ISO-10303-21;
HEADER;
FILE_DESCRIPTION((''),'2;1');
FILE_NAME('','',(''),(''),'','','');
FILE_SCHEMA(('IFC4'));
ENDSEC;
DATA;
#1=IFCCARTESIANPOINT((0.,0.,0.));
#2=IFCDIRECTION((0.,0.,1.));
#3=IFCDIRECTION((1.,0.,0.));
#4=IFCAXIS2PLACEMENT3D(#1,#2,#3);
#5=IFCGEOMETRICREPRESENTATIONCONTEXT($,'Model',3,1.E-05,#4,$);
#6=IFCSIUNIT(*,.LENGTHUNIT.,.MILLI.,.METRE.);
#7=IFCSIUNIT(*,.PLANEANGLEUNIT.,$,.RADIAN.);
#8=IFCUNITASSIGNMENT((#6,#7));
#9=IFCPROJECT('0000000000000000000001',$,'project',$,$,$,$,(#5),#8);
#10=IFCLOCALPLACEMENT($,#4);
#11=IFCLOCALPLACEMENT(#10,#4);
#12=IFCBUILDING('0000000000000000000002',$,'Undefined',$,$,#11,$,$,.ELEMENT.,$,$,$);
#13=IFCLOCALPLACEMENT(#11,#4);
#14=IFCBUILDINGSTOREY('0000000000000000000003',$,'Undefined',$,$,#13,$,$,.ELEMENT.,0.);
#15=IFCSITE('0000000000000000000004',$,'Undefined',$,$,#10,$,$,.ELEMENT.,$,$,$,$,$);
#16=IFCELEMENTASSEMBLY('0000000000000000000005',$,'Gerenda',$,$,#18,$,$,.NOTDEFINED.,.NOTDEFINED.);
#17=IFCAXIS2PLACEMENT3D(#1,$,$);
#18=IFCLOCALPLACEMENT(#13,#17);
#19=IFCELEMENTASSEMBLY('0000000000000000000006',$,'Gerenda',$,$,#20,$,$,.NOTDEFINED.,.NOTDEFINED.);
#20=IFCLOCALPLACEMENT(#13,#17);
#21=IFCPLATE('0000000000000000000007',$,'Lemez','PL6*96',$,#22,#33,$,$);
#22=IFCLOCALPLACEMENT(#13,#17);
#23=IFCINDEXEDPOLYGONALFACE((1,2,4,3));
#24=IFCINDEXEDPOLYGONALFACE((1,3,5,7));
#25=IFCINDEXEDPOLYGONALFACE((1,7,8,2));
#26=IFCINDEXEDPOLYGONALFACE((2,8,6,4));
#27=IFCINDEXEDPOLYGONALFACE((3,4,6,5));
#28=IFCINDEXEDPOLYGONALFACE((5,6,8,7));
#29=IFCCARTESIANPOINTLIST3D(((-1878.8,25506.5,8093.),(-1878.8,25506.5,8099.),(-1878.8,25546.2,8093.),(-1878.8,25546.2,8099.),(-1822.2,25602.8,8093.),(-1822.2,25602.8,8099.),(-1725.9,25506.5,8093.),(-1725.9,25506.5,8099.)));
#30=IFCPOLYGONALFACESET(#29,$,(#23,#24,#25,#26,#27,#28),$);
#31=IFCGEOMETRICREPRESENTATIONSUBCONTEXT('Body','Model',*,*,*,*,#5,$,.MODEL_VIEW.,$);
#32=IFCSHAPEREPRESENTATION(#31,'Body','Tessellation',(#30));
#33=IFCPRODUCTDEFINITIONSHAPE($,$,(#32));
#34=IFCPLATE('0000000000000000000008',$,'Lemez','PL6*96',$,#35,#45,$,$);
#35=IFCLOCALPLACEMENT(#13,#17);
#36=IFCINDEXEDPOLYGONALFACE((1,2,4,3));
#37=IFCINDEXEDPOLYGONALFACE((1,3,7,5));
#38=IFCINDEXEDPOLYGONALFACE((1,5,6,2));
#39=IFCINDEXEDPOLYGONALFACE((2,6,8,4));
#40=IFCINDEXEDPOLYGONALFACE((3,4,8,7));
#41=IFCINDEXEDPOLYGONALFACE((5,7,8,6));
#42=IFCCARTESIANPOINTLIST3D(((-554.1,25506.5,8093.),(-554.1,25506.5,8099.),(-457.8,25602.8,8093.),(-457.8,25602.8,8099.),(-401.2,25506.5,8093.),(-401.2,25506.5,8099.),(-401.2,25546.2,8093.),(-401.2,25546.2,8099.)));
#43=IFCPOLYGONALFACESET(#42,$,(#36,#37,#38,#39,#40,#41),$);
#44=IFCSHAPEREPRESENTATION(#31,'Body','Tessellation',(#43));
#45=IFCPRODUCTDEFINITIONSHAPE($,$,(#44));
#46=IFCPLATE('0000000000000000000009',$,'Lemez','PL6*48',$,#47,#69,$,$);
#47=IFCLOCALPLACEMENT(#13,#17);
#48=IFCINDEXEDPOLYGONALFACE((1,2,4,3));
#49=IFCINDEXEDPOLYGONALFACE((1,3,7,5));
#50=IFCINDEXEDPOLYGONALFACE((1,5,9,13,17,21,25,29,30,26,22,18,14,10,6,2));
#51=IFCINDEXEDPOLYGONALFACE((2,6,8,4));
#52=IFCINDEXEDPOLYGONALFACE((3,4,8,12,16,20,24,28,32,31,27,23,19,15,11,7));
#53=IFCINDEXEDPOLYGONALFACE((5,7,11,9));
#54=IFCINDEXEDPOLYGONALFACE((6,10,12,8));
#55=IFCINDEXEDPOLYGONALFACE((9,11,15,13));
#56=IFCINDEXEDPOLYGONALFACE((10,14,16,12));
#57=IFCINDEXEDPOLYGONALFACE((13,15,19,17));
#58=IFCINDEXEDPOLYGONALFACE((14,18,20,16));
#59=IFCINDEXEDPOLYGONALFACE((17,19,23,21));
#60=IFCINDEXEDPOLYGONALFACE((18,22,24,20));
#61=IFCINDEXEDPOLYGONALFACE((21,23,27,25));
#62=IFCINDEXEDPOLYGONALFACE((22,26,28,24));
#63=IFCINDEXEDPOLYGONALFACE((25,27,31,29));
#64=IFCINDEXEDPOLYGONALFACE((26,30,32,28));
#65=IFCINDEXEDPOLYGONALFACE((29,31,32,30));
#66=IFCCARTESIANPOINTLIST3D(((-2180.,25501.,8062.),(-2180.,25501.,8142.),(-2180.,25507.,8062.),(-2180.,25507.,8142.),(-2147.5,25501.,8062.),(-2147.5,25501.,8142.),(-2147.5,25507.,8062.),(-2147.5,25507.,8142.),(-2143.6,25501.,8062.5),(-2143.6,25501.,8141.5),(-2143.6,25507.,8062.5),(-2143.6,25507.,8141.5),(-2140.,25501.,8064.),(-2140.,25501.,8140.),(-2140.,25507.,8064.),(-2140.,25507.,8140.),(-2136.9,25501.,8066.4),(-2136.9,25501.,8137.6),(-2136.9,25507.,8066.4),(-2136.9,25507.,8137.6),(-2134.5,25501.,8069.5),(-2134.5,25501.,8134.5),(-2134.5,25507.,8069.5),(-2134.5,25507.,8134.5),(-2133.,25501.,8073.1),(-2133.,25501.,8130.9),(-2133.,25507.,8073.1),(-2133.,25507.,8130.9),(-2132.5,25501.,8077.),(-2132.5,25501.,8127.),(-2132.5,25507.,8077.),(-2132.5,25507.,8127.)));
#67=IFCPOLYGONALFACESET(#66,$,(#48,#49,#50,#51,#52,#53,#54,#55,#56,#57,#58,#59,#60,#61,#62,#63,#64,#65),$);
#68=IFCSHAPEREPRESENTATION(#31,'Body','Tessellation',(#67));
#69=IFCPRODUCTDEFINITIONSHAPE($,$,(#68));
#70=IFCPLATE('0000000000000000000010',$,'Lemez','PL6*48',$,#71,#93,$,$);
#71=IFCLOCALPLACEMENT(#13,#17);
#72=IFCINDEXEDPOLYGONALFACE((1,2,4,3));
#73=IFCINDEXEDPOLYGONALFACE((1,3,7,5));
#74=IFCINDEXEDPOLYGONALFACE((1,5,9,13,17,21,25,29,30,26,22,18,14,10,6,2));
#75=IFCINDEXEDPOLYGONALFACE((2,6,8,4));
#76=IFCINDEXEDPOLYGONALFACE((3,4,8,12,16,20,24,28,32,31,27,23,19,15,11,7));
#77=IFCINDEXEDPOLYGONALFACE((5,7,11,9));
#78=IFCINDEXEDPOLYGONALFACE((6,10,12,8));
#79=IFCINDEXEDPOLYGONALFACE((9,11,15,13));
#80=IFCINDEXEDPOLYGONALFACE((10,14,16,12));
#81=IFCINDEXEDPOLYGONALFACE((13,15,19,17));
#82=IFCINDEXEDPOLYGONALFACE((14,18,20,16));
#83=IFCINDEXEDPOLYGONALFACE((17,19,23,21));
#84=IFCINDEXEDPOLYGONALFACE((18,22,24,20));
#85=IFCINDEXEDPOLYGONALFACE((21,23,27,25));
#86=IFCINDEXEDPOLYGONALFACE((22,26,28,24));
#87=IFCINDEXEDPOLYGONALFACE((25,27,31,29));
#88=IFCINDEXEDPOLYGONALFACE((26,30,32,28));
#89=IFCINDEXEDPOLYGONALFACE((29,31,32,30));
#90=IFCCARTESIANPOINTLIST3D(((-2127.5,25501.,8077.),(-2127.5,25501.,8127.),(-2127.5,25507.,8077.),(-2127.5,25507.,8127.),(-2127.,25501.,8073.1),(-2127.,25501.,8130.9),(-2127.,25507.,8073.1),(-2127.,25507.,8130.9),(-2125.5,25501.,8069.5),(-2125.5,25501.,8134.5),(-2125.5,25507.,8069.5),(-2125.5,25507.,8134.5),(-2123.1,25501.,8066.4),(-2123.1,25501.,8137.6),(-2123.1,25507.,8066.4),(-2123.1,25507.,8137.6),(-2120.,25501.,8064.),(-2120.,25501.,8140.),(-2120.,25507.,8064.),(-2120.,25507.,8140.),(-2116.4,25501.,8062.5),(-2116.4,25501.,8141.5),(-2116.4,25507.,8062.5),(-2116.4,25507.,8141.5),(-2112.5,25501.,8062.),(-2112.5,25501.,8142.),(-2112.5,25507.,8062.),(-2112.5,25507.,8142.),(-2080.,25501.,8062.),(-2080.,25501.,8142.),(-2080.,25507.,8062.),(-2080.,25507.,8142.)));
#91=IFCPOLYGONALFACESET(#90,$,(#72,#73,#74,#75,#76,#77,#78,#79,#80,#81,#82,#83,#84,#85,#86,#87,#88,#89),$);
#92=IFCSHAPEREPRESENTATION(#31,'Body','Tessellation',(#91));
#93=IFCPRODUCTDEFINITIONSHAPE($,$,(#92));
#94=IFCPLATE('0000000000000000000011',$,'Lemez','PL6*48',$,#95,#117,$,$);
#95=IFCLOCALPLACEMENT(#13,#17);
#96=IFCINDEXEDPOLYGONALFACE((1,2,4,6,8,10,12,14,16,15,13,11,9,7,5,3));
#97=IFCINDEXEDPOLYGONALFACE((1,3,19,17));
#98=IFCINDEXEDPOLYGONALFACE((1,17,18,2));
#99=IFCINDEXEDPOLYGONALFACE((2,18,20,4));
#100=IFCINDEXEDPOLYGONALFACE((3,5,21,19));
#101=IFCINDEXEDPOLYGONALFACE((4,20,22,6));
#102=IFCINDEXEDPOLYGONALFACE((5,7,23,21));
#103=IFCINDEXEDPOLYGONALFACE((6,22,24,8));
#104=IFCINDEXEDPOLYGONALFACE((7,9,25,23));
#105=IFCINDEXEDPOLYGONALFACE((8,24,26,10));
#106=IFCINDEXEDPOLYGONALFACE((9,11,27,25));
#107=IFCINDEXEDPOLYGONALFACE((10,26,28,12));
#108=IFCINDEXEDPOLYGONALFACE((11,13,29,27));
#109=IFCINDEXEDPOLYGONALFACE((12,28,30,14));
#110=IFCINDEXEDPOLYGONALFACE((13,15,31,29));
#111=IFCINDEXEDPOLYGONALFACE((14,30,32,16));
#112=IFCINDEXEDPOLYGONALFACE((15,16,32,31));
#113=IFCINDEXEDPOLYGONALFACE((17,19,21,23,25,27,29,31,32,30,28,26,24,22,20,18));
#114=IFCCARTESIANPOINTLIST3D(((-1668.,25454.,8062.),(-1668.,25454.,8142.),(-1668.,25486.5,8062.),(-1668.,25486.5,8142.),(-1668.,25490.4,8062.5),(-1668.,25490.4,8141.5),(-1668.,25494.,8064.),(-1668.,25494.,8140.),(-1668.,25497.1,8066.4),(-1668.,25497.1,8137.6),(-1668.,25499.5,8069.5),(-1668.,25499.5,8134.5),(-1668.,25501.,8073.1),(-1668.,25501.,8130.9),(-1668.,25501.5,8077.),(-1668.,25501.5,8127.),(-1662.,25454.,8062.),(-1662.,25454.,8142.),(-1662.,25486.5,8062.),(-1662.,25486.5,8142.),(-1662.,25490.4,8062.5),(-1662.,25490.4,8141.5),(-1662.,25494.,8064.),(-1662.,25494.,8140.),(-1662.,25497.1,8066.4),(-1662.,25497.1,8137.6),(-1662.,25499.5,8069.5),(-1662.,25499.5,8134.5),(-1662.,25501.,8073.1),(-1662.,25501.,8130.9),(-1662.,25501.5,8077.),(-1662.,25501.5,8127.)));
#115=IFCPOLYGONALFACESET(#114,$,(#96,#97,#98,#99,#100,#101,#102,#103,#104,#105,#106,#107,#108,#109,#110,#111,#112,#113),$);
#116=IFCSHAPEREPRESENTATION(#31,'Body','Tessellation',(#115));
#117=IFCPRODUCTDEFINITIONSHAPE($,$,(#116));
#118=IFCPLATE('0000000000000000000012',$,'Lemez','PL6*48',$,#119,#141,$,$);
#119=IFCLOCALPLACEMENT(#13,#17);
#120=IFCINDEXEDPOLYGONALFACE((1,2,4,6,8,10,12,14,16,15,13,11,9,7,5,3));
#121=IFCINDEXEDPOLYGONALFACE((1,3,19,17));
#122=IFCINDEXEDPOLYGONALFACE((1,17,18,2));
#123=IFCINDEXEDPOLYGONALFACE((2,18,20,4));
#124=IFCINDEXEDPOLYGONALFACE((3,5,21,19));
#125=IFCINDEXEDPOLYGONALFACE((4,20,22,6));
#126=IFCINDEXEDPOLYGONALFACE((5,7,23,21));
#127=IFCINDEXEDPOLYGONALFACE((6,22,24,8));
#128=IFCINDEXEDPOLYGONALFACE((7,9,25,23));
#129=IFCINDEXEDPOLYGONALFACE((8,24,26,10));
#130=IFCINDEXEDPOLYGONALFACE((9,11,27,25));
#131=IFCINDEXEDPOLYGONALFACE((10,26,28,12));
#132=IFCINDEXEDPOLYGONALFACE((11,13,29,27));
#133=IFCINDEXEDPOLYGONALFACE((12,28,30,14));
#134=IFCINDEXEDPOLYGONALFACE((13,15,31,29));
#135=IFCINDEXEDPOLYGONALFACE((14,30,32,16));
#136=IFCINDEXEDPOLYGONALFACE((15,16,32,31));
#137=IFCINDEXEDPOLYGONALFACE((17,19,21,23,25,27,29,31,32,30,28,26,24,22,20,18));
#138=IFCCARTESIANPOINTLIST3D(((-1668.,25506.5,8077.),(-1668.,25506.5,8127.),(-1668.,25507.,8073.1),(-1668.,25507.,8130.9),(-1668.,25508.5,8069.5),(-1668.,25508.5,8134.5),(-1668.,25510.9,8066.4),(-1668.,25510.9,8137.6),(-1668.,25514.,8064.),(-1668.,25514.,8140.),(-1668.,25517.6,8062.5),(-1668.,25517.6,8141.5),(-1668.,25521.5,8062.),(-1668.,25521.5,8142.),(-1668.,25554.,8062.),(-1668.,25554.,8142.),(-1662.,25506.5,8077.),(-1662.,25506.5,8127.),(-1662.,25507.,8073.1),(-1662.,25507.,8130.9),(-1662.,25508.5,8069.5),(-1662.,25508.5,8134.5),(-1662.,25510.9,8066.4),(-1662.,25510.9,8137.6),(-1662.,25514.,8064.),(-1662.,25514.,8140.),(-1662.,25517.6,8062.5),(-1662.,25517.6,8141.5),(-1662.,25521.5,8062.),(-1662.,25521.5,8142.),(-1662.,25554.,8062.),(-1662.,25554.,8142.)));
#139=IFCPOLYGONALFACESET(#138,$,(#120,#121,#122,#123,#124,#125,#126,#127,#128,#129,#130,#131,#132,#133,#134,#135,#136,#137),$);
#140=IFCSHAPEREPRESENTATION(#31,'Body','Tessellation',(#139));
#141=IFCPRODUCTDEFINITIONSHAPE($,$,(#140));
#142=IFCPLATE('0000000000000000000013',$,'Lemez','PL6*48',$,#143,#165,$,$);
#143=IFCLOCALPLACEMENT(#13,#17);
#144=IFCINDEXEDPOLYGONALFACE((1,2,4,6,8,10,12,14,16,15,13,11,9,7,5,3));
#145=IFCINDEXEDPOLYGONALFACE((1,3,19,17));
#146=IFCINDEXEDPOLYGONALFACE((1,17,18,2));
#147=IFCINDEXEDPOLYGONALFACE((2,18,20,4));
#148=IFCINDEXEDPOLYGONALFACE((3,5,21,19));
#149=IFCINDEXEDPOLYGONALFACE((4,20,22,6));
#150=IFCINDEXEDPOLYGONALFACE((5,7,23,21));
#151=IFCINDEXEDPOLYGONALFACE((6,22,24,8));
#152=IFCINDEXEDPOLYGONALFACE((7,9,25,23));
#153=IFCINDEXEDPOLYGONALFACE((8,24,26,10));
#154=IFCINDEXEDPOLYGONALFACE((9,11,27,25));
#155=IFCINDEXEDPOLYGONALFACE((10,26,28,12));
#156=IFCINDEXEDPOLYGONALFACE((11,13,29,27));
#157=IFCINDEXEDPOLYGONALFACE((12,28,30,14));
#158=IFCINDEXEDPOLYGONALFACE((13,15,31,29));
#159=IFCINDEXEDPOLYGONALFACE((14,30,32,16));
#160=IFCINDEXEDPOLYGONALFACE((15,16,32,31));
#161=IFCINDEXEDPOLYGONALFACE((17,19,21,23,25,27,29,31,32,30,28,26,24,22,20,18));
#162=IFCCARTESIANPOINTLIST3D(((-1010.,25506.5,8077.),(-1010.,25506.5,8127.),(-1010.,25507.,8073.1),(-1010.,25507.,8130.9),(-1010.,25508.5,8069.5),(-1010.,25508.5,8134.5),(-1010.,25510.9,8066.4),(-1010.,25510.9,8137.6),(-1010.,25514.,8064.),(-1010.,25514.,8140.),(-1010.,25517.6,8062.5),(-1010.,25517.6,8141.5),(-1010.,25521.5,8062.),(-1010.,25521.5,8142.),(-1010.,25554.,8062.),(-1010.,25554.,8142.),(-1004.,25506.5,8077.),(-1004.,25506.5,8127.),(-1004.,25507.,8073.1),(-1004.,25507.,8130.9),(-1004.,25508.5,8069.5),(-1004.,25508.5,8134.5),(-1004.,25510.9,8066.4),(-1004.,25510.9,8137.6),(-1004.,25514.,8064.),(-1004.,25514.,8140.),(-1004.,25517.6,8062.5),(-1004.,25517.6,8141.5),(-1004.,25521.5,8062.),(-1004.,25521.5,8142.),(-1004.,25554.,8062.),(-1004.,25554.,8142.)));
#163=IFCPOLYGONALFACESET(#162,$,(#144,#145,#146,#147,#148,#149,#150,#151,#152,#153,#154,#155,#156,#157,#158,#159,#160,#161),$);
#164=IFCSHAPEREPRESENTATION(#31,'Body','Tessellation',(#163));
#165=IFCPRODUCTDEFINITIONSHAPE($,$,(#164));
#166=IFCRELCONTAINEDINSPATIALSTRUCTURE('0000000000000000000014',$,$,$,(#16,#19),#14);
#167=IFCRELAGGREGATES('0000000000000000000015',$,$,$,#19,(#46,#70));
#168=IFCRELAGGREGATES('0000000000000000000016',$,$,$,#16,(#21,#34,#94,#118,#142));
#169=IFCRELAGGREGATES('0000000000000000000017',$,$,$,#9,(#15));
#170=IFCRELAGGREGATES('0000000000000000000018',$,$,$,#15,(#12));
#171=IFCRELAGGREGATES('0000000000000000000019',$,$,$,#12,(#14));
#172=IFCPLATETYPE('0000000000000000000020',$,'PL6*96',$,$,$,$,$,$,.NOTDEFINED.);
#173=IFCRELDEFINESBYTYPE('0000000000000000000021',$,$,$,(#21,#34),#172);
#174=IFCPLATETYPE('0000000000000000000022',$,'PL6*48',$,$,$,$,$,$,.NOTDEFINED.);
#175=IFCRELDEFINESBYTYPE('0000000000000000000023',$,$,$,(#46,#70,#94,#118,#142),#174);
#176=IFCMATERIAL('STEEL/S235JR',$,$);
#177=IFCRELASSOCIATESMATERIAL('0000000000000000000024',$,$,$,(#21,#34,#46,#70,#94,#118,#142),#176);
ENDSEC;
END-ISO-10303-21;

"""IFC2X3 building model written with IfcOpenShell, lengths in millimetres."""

from ifc_helpers import new_model, si_unit, frame, frame_2d, origin_with_axes, place, context, subcontext, project, spatial, polyline, circle_curve, parameter, trimmed, segment, composite_curve, outline, extrude, material, type_object, element, aggregate, save


model = new_model("IFC2X3")

# Units and contexts
model_context = context("Model", 3, precision=1e-05, world=origin_with_axes())
body_context = subcontext(model_context, "Body", "Model", "MODEL_VIEW")
ifc_project = project(units=[si_unit("LENGTHUNIT", "METRE", prefix="MILLI"), si_unit("PLANEANGLEUNIT", "RADIAN")], contexts=[model_context])

# Site, building, storey
site_placement = place(None, origin_with_axes())
site = spatial("IfcSite", under=ifc_project, at=site_placement, Name="Undefined", CompositionType="ELEMENT")
building_placement = place(site_placement, origin_with_axes())
building = spatial("IfcBuilding", under=site, at=building_placement, Name="Undefined", CompositionType="ELEMENT")
storey_placement = place(building_placement, origin_with_axes())
storey = spatial("IfcBuildingStorey", under=building, at=storey_placement, Name="Undefined", CompositionType="ELEMENT", Elevation=0.0)

# Element assemblies
ifc_material_1 = material(Name="STEEL/S235JR")
assembly_1_placement = place(storey_placement, origin_with_axes())
assembly_1 = element("IfcElementAssembly", 1, at=assembly_1_placement, inside=storey, Name="Gerenda", AssemblyPlace="NOTDEFINED", PredefinedType="NOTDEFINED")
assembly_2_placement = place(storey_placement, origin_with_axes())
assembly_2 = element("IfcElementAssembly", 2, at=assembly_2_placement, inside=storey, Name="Gerenda", AssemblyPlace="NOTDEFINED", PredefinedType="NOTDEFINED")

# Plates
plate_type_1 = type_object("IfcPlateType", Name="PL6*96", PredefinedType="NOTDEFINED")
plate_1_placement = place(assembly_1_placement, frame((-1878.8, 25506.5, 8096.0), z_axis=(0.0, 0.0, 1.0), x_axis=(1.0, -0.000003, 0.0)))
plate_1 = element("IfcPlate", 3, at=plate_1_placement, type_object=plate_type_1, material=ifc_material_1, Name="Lemez", Description="PL6*96", context=body_context, shape_type="SweptSolid", body=[
    extrude(outline(polyline([(0.0, 0.0), (152.9, 0.0), (56.6, 96.3), (0.0, 39.7), (0.0, 0.0)])), frame((0.0, 0.0, -3.0), z_axis=(0.0, 0.0, 1.0), x_axis=(1.0, 0.0, 0.0)), (0.0, 0.0, 1.0), 6.0),
])
plate_2_placement = place(assembly_1_placement, frame((-554.1, 25506.5, 8096.0), z_axis=(0.0, 0.0, 1.0), x_axis=(1.0, -0.000003, 0.0)))
plate_2 = element("IfcPlate", 4, at=plate_2_placement, type_object=plate_type_1, material=ifc_material_1, Name="Lemez", Description="PL6*96", context=body_context, shape_type="SweptSolid", body=[
    extrude(outline(polyline([(0.0, 0.0), (152.9, 0.0), (152.9, 39.7), (96.3, 96.3), (0.0, 0.0)])), frame((0.0, 0.0, -3.0), z_axis=(0.0, 0.0, 1.0), x_axis=(1.0, 0.0, 0.0)), (0.0, 0.0, 1.0), 6.0),
])
plate_type_2 = type_object("IfcPlateType", Name="PL6*48", PredefinedType="NOTDEFINED")
plate_3_placement = place(assembly_2_placement, frame((-2132.5, 25504.0, 8062.0), z_axis=(0.000004, 1.0, 0.0), x_axis=(-1.0, 0.000004, 0.0)))
plate_3 = element("IfcPlate", 5, at=plate_3_placement, type_object=plate_type_2, material=ifc_material_1, Name="Lemez", Description="PL6*48", context=body_context, shape_type="SweptSolid", body=[
    extrude(outline(composite_curve([segment(trimmed(circle_curve(frame_2d((15.0, 15.0), x_axis=(-1.0, 0.0)), 15.0), [parameter(0.0)], [parameter(1.570796)], True, "PARAMETER"), True, "CONTINUOUS"), segment(polyline([(15.0, 0.0), (47.5, 0.0), (47.5, 80.0), (15.0, 80.0)]), True, "CONTINUOUS"), segment(trimmed(circle_curve(frame_2d((15.0, 65.0), x_axis=(0.0, 1.0)), 15.0), [parameter(0.0)], [parameter(1.570796)], True, "PARAMETER"), True, "CONTINUOUS"), segment(polyline([(0.0, 65.0), (0.0, 15.0)]), True, "CONTINUOUS")], self_intersect=True)), frame((0.0, 0.0, -3.0), z_axis=(0.0, 0.0, 1.0), x_axis=(1.0, 0.0, 0.0)), (0.0, 0.0, 1.0), 6.0),
])
plate_4_placement = place(assembly_2_placement, frame((-2127.5, 25504.0, 8062.0), z_axis=(-0.000004, -1.0, 0.0), x_axis=(1.0, -0.000004, 0.0)))
plate_4 = element("IfcPlate", 6, at=plate_4_placement, type_object=plate_type_2, material=ifc_material_1, Name="Lemez", Description="PL6*48", context=body_context, shape_type="SweptSolid", body=[
    extrude(outline(composite_curve([segment(trimmed(circle_curve(frame_2d((15.0, 15.0), x_axis=(-1.0, 0.0)), 15.0), [parameter(0.0)], [parameter(1.570796)], True, "PARAMETER"), True, "CONTINUOUS"), segment(polyline([(15.0, 0.0), (47.5, 0.0), (47.5, 80.0), (15.0, 80.0)]), True, "CONTINUOUS"), segment(trimmed(circle_curve(frame_2d((15.0, 65.0), x_axis=(0.0, 1.0)), 15.0), [parameter(0.0)], [parameter(1.570796)], True, "PARAMETER"), True, "CONTINUOUS"), segment(polyline([(0.0, 65.0), (0.0, 15.0)]), True, "CONTINUOUS")], self_intersect=True)), frame((0.0, 0.0, -3.0), z_axis=(0.0, 0.0, 1.0), x_axis=(1.0, 0.0, 0.0)), (0.0, 0.0, 1.0), 6.0),
])
aggregate(assembly_2, [plate_3, plate_4])
plate_5_placement = place(assembly_1_placement, frame((-1665.0, 25501.5, 8062.0), z_axis=(-1.0, 0.000003, 0.0), x_axis=(-0.000003, -1.0, 0.0)))
plate_5 = element("IfcPlate", 7, at=plate_5_placement, type_object=plate_type_2, material=ifc_material_1, Name="Lemez", Description="PL6*48", context=body_context, shape_type="SweptSolid", body=[
    extrude(outline(composite_curve([segment(trimmed(circle_curve(frame_2d((15.0, 15.0), x_axis=(-1.0, 0.0)), 15.0), [parameter(0.0)], [parameter(1.570796)], True, "PARAMETER"), True, "CONTINUOUS"), segment(polyline([(15.0, 0.0), (47.5, 0.0), (47.5, 80.0), (15.0, 80.0)]), True, "CONTINUOUS"), segment(trimmed(circle_curve(frame_2d((15.0, 65.0), x_axis=(0.0, 1.0)), 15.0), [parameter(0.0)], [parameter(1.570796)], True, "PARAMETER"), True, "CONTINUOUS"), segment(polyline([(0.0, 65.0), (0.0, 15.0)]), True, "CONTINUOUS")], self_intersect=True)), frame((0.0, 0.0, -3.0), z_axis=(0.0, 0.0, 1.0), x_axis=(1.0, 0.0, 0.0)), (0.0, 0.0, 1.0), 6.0),
])
plate_6_placement = place(assembly_1_placement, frame((-1665.0, 25506.5, 8062.0), z_axis=(1.0, -0.000003, 0.0), x_axis=(0.000003, 1.0, 0.0)))
plate_6 = element("IfcPlate", 8, at=plate_6_placement, type_object=plate_type_2, material=ifc_material_1, Name="Lemez", Description="PL6*48", context=body_context, shape_type="SweptSolid", body=[
    extrude(outline(composite_curve([segment(trimmed(circle_curve(frame_2d((15.0, 15.0), x_axis=(-1.0, 0.0)), 15.0), [parameter(0.0)], [parameter(1.570796)], True, "PARAMETER"), True, "CONTINUOUS"), segment(polyline([(15.0, 0.0), (47.5, 0.0), (47.5, 80.0), (15.0, 80.0)]), True, "CONTINUOUS"), segment(trimmed(circle_curve(frame_2d((15.0, 65.0), x_axis=(0.0, 1.0)), 15.0), [parameter(0.0)], [parameter(1.570796)], True, "PARAMETER"), True, "CONTINUOUS"), segment(polyline([(0.0, 65.0), (0.0, 15.0)]), True, "CONTINUOUS")], self_intersect=True)), frame((0.0, 0.0, -3.0), z_axis=(0.0, 0.0, 1.0), x_axis=(1.0, 0.0, 0.0)), (0.0, 0.0, 1.0), 6.0),
])
plate_7_placement = place(assembly_1_placement, frame((-1007.0, 25506.5, 8062.0), z_axis=(1.0, -0.000003, 0.0), x_axis=(0.000003, 1.0, 0.0)))
plate_7 = element("IfcPlate", 9, at=plate_7_placement, type_object=plate_type_2, material=ifc_material_1, Name="Lemez", Description="PL6*48", context=body_context, shape_type="SweptSolid", body=[
    extrude(outline(composite_curve([segment(trimmed(circle_curve(frame_2d((15.0, 15.0), x_axis=(-1.0, 0.0)), 15.0), [parameter(0.0)], [parameter(1.570796)], True, "PARAMETER"), True, "CONTINUOUS"), segment(polyline([(15.0, 0.0), (47.5, 0.0), (47.5, 80.0), (15.0, 80.0)]), True, "CONTINUOUS"), segment(trimmed(circle_curve(frame_2d((15.0, 65.0), x_axis=(0.0, 1.0)), 15.0), [parameter(0.0)], [parameter(1.570796)], True, "PARAMETER"), True, "CONTINUOUS"), segment(polyline([(0.0, 65.0), (0.0, 15.0)]), True, "CONTINUOUS")], self_intersect=True)), frame((0.0, 0.0, -3.0), z_axis=(0.0, 0.0, 1.0), x_axis=(1.0, 0.0, 0.0)), (0.0, 0.0, 1.0), 6.0),
])

aggregate(assembly_1, [plate_1, plate_2, plate_5, plate_6, plate_7])

save(model, "model.ifc")
